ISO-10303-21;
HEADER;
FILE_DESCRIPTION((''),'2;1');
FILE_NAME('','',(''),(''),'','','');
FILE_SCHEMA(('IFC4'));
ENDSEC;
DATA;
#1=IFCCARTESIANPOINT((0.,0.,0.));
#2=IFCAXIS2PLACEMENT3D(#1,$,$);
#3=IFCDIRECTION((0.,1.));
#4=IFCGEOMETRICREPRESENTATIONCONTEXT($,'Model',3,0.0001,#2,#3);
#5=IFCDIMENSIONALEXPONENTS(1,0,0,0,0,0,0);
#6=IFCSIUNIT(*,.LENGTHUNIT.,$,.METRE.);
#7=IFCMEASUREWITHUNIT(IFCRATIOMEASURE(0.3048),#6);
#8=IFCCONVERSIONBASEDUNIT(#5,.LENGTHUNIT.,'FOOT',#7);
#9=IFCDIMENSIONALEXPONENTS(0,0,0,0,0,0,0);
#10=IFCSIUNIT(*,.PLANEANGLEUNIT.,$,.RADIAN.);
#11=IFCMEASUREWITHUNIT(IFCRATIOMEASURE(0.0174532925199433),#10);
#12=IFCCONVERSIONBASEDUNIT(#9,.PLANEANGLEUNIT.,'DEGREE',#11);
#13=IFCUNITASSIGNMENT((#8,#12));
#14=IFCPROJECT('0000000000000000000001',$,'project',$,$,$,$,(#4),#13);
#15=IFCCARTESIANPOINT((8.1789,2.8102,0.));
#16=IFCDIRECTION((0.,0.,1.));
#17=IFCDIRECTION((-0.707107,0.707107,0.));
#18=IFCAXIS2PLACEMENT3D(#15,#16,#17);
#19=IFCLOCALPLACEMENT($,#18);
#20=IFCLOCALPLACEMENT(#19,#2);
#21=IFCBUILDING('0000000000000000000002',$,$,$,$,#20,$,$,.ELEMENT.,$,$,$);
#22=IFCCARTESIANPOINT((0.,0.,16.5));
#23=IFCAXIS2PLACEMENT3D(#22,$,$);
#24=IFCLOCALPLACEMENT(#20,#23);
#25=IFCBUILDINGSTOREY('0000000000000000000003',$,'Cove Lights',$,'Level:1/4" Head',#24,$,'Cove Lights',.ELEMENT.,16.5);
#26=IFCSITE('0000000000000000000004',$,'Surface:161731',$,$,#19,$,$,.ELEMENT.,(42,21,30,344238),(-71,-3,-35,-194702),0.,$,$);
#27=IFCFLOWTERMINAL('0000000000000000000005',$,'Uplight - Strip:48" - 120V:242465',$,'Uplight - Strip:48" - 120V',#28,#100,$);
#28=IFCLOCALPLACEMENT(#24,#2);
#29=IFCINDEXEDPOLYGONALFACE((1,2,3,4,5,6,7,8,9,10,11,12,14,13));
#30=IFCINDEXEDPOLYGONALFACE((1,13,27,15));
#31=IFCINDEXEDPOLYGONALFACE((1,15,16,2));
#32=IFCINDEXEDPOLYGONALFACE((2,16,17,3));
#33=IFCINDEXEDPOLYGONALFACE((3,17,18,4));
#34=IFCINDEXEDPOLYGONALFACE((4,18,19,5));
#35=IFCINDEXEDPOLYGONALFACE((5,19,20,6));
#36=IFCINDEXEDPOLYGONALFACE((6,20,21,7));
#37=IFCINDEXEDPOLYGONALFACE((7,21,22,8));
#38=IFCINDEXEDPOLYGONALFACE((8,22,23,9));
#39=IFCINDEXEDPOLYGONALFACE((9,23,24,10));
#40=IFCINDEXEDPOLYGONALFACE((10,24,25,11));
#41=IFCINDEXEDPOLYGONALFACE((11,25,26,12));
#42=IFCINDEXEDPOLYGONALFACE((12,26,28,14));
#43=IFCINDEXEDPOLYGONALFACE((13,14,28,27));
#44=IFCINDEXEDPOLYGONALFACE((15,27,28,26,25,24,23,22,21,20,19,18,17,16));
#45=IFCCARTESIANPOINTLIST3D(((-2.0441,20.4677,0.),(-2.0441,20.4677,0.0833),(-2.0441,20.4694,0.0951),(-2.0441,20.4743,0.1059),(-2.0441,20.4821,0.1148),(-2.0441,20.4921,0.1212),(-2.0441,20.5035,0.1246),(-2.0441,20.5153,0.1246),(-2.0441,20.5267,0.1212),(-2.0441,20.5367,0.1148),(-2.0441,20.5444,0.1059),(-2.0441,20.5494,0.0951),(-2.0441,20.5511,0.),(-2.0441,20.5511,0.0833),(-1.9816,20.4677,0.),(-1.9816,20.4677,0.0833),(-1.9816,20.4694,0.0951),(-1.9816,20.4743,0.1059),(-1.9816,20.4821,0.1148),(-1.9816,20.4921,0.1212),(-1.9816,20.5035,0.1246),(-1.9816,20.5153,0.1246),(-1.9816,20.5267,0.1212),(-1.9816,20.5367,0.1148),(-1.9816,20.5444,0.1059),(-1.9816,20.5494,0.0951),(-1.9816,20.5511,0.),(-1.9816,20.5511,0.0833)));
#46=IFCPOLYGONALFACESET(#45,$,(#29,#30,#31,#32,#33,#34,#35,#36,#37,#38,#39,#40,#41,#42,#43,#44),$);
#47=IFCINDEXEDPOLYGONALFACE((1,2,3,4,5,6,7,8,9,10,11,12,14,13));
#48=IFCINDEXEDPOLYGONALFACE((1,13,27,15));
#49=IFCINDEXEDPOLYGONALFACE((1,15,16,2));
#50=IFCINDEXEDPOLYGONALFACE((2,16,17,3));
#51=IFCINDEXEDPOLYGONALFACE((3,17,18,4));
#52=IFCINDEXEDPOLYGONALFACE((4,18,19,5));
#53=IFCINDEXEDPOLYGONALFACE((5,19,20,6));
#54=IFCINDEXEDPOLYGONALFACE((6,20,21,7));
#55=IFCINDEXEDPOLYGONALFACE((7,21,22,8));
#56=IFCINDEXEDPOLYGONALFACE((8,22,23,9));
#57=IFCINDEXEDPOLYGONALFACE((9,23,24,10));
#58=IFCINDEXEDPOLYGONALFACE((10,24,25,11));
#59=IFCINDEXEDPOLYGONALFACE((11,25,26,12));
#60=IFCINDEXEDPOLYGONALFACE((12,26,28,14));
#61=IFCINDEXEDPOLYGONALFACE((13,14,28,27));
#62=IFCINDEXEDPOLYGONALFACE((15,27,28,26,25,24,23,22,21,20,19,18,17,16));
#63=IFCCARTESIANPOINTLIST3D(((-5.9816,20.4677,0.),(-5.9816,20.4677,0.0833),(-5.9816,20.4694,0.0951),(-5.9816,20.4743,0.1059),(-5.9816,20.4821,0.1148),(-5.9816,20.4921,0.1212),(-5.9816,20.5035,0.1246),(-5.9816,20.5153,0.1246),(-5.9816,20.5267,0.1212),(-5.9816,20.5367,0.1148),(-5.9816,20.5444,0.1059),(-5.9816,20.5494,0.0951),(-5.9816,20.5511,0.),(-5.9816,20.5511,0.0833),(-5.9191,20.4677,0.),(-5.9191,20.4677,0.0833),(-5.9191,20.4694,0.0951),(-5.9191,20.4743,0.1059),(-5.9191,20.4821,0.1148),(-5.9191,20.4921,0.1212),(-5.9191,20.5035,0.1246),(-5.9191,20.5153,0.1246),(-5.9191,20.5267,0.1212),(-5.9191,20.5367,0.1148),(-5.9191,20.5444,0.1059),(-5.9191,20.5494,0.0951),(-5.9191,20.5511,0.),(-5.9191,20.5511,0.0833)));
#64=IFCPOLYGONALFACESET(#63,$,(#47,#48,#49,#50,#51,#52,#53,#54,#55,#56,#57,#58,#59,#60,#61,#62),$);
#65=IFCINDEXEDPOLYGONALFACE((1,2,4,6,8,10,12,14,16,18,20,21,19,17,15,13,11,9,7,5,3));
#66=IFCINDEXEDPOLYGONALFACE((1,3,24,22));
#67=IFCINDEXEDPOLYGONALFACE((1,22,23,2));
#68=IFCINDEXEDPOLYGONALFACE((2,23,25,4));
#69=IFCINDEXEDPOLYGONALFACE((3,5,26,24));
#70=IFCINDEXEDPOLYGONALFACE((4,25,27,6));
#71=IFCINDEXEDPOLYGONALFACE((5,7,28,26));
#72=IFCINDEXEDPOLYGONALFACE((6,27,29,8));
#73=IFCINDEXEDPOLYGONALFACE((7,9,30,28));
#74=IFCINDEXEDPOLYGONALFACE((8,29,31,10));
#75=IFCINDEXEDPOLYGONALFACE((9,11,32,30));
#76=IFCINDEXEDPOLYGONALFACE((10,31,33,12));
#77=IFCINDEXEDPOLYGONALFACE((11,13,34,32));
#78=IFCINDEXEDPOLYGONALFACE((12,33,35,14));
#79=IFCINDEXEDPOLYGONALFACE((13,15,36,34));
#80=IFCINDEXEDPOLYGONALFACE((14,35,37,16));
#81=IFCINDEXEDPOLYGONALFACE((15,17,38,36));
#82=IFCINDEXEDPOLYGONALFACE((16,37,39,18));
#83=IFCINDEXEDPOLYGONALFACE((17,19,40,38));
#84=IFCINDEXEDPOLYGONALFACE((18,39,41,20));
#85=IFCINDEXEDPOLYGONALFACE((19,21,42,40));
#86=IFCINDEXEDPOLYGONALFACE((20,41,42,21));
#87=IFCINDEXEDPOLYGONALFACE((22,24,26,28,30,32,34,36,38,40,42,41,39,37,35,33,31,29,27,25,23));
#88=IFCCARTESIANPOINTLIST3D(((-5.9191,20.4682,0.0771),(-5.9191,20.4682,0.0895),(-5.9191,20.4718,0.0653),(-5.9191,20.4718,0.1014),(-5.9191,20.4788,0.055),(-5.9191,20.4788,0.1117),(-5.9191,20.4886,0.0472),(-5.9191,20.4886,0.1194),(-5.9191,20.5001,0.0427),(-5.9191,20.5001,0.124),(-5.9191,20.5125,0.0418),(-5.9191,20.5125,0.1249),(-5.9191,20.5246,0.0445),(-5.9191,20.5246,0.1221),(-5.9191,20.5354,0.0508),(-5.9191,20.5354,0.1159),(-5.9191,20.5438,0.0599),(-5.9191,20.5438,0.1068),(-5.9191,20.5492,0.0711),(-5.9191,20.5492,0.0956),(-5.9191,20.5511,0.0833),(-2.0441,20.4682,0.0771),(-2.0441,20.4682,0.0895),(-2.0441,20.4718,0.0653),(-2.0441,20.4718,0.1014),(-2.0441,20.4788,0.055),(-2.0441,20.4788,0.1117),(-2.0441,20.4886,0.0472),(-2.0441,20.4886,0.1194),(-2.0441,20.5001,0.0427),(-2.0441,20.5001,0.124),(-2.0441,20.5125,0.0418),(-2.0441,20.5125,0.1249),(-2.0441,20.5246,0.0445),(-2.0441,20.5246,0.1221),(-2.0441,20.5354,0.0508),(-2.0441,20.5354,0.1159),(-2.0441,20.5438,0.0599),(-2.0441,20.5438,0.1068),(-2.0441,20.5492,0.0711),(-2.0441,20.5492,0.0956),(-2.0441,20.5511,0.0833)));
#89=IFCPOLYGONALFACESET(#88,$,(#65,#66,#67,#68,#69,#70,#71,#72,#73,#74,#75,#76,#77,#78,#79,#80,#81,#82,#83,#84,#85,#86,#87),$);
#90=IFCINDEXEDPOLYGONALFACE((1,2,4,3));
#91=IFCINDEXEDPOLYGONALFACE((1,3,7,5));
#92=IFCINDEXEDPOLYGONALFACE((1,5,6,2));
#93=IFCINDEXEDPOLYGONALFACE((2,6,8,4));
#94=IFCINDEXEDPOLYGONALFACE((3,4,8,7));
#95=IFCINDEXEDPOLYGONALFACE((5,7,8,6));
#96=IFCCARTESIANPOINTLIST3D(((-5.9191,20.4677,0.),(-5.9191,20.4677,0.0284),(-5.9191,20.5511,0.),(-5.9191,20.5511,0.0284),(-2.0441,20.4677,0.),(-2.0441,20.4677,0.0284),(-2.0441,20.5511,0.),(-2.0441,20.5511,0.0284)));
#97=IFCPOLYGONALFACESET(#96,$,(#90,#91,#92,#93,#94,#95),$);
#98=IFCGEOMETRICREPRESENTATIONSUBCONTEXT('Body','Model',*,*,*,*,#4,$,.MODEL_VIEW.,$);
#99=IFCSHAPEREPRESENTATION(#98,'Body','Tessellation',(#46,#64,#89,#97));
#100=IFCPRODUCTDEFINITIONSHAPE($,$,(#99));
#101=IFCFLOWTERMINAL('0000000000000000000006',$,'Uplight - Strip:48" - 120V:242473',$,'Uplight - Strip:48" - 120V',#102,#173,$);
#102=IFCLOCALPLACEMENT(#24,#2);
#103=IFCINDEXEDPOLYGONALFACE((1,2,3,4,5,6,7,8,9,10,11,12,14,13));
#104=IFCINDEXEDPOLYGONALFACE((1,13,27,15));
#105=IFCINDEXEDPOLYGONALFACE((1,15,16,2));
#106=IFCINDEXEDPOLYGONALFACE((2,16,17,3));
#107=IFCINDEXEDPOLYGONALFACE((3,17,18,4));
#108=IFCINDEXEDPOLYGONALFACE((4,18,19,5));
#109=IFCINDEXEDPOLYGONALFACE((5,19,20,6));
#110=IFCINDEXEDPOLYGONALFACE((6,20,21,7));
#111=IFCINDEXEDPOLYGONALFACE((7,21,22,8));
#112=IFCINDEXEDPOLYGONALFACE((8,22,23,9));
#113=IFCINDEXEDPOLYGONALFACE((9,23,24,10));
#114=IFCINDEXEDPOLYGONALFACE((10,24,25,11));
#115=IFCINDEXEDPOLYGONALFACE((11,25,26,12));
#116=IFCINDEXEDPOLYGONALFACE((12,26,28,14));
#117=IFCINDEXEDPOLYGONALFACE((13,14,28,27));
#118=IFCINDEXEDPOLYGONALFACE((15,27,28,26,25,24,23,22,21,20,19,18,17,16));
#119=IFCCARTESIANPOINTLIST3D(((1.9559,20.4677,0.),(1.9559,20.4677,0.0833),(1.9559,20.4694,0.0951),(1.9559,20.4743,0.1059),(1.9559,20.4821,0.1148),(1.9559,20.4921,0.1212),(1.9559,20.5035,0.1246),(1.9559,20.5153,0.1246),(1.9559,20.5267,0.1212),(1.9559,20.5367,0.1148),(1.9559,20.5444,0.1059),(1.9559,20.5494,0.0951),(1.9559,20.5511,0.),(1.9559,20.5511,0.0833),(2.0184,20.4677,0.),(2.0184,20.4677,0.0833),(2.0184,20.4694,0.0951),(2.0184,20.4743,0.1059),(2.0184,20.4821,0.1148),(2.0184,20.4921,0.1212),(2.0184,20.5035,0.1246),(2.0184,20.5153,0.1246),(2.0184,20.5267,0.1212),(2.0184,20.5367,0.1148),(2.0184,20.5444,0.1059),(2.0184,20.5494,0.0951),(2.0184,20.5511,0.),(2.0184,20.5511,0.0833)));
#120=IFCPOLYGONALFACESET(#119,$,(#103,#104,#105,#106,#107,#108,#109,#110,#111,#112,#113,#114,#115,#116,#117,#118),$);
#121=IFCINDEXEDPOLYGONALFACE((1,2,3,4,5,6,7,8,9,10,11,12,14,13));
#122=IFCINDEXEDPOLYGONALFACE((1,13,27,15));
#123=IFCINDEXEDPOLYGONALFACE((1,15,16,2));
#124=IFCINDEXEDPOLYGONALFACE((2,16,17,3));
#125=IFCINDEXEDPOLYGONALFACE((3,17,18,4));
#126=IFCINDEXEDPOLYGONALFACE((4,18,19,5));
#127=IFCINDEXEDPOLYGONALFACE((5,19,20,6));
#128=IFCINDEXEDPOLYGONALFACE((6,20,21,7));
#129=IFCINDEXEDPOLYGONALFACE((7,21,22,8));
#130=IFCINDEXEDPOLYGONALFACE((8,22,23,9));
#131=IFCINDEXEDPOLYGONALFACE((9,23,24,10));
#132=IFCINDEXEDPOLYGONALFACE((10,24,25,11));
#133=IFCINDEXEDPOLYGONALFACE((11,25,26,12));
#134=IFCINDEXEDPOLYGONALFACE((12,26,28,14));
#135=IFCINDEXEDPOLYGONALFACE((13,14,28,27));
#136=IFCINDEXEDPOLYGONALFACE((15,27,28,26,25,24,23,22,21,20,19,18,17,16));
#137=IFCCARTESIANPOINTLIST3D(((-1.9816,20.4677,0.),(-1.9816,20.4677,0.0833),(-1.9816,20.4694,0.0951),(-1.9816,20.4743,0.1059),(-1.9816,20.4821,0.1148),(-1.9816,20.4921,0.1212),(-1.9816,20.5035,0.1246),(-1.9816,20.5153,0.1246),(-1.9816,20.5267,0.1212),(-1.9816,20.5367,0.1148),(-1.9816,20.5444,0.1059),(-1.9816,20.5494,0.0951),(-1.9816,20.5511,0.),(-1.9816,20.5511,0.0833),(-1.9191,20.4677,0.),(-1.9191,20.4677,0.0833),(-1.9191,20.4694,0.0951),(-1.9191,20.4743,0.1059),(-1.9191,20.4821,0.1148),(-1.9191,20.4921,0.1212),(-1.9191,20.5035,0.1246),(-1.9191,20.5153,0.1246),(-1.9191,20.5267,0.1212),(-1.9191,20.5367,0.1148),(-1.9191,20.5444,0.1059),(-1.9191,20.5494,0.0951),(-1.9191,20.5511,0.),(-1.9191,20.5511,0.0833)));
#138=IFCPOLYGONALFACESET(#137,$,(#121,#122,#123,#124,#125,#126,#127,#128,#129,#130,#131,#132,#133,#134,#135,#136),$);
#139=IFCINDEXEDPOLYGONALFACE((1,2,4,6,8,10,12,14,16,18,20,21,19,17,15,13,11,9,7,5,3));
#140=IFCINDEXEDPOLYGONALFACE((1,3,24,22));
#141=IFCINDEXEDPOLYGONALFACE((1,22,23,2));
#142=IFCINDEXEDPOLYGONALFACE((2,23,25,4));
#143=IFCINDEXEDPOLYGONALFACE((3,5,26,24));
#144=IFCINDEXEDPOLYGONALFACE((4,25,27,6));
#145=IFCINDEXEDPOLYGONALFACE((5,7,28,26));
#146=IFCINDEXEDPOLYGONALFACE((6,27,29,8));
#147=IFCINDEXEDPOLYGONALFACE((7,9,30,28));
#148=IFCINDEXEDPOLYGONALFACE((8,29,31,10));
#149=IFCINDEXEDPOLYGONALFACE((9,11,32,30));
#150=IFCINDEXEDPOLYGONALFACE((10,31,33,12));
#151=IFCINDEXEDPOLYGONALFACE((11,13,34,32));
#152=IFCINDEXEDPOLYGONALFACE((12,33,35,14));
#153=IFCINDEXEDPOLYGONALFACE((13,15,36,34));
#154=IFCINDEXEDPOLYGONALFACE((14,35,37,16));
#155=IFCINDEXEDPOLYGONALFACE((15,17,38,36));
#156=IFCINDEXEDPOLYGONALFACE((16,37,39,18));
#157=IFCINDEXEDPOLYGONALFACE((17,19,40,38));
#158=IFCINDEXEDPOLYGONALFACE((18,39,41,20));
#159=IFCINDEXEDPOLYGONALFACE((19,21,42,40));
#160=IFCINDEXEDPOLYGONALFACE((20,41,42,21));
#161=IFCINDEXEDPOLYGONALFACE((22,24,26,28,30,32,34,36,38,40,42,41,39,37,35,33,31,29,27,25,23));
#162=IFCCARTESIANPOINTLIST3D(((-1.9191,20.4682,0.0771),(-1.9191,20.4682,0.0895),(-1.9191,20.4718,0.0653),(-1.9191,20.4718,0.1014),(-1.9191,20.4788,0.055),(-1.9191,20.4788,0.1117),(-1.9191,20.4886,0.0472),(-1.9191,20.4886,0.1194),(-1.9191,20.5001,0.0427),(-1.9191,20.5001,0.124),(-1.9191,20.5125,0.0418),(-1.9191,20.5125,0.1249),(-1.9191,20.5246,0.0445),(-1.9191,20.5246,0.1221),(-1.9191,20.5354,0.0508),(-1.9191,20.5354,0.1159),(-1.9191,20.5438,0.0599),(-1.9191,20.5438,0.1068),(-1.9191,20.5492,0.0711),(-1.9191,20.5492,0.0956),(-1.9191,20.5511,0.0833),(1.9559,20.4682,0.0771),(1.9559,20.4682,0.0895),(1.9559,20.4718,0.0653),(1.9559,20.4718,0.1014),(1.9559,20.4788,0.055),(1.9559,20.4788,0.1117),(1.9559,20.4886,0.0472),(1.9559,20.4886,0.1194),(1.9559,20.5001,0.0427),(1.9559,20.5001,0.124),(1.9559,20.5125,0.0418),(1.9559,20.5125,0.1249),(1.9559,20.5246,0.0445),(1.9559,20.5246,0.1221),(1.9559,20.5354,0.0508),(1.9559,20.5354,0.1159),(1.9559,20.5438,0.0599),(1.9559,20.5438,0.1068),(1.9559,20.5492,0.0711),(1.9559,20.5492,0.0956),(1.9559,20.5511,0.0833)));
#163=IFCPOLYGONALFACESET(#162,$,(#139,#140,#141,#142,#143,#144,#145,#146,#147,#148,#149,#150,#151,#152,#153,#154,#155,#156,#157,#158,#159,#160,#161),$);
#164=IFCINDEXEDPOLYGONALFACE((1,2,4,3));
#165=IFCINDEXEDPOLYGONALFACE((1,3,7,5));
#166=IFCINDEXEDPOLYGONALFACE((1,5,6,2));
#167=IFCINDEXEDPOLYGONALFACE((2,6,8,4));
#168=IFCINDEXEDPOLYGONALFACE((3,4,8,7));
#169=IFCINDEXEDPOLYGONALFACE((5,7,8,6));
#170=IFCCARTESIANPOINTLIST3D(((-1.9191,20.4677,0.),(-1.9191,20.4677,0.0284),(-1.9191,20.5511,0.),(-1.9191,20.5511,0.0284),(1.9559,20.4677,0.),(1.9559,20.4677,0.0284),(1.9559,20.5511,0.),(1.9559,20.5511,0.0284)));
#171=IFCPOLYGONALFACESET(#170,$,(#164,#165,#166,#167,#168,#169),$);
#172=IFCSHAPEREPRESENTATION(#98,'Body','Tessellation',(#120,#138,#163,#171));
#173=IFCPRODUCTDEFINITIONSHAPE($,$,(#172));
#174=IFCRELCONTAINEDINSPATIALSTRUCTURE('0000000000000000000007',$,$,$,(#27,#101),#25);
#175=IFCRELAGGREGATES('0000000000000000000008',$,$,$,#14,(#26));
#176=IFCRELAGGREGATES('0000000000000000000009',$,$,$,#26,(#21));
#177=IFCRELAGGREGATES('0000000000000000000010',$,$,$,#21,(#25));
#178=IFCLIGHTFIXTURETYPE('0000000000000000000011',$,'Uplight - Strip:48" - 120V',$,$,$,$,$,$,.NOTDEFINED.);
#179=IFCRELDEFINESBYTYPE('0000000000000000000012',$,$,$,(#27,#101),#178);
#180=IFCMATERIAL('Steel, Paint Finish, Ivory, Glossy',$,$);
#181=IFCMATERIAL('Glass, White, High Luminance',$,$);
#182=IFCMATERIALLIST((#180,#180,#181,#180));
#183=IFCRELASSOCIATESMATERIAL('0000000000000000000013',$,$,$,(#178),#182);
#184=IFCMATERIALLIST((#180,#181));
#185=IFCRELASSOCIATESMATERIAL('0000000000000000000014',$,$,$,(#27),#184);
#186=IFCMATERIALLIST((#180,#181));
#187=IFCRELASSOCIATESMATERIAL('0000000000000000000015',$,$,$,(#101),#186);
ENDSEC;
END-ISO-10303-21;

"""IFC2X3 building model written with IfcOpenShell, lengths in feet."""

from ifc_helpers import new_model, entity, si_unit, converted_unit, direction, frame, frame_2d, origin, origin_2d_with_axis, place, context, subcontext, project, spatial, polyline, circle_curve, parameter, trimmed, segment, composite_curve, rectangle, circle, outline, extrude, source, transform, mapped, material, material_list, type_object, type_shapes, element, save


model = new_model("IFC2X3")

# Units and contexts
model_context = context("Model", 3, precision=0.0001, world=origin(), true_north=direction((0.0, 1.0)))
body_context = subcontext(model_context, "Body", "Model", "MODEL_VIEW")
ifc_project = project(units=[converted_unit("LENGTHUNIT", "FOOT", entity("IfcRatioMeasure", 0.3048), si_unit("LENGTHUNIT", "METRE"), dimensions=[1, 0, 0, 0, 0, 0, 0]), converted_unit("PLANEANGLEUNIT", "DEGREE", entity("IfcRatioMeasure", 0.0174532925199433), si_unit("PLANEANGLEUNIT", "RADIAN"), dimensions=[0, 0, 0, 0, 0, 0, 0])], contexts=[model_context])

# Site, building, storey
site_placement = place(None, frame((8.1789, 2.8102, 0.0), z_axis=(0.0, 0.0, 1.0), x_axis=(-0.707107, 0.707107, 0.0)))
site = spatial("IfcSite", under=ifc_project, at=site_placement, Name="Surface:161731", CompositionType="ELEMENT", RefLatitude=(42, 21, 30, 344238), RefLongitude=(-71, -3, -35, -194702), RefElevation=0.0)
building_placement = place(site_placement, origin())
building = spatial("IfcBuilding", under=site, at=building_placement, CompositionType="ELEMENT")
storey_placement = place(building_placement, frame((0.0, 0.0, 16.5)))
storey = spatial("IfcBuildingStorey", under=building, at=storey_placement, Name="Cove Lights", ObjectType="Level:1/4\" Head", LongName="Cove Lights", CompositionType="ELEMENT", Elevation=16.5)

# Flow terminals
ifc_material_1 = material(Name="Steel, Paint Finish, Ivory, Glossy")
ifc_material_2 = material(Name="Glass, White, High Luminance")
ifc_material_list_1 = material_list([ifc_material_1, ifc_material_1, ifc_material_2, ifc_material_1])
light_fixture_type_1 = type_object("IfcLightFixtureType", Name="Uplight - Strip:48\" - 120V", PredefinedType="NOTDEFINED", material=ifc_material_list_1)
shared_shape_1 = source(origin(), body_context, "Body", "SweptSolid", [
    extrude(outline(composite_curve([segment(polyline([(-0.0417, -0.0417), (0.0417, -0.0417)]), True, "CONTINUOUS"), segment(trimmed(circle_curve(frame_2d((0.0417, 0.0), x_axis=(0.0, -1.0)), 0.0417), [parameter(0.0)], [parameter(180.0)], True, "PARAMETER"), True, "CONTINUOUS"), segment(polyline([(0.0417, 0.0417), (-0.0417, 0.0417)]), True, "CONTINUOUS"), segment(polyline([(-0.0417, 0.0417), (-0.0417, -0.0417)]), True, "CONTINUOUS")], self_intersect=False)), frame((1.9375, 0.0, 0.0417), z_axis=(1.0, 0.0, 0.0), x_axis=(0.0, 0.0, 1.0)), (0.0, 0.0, 1.0), 0.0625),
    extrude(outline(composite_curve([segment(polyline([(-0.0417, -0.0417), (0.0417, -0.0417)]), True, "CONTINUOUS"), segment(polyline([(0.0417, -0.0417), (0.0417, 0.0417)]), True, "CONTINUOUS"), segment(trimmed(circle_curve(frame_2d((0.0, 0.0417), x_axis=(0.0, 1.0)), 0.0417), [parameter(270.0)], [parameter(90.0)], True, "PARAMETER"), True, "CONTINUOUS"), segment(polyline([(-0.0417, 0.0417), (-0.0417, -0.0417)]), True, "CONTINUOUS")], self_intersect=False)), frame((-2.0, 0.0, 0.0417), z_axis=(1.0, 0.0, 0.0), x_axis=(0.0, 1.0, 0.0)), (0.0, 0.0, 1.0), 0.0625),
    extrude(circle(Radius=0.0417, at=frame_2d((0.0, 0.0), x_axis=(1.0, 0.0))), frame((-1.9375, 0.0, 0.0833), z_axis=(1.0, 0.0, 0.0), x_axis=(0.0, 1.0, 0.0)), (0.0, 0.0, 1.0), 3.875),
    extrude(rectangle(XDim=3.875, YDim=0.0833, at=origin_2d_with_axis()), frame((0.0, 0.0, 0.0), z_axis=(0.0, 0.0, 1.0), x_axis=(-1.0, 0.0, 0.0)), (0.0, 0.0, 1.0), 0.0284),
])
type_shapes(light_fixture_type_1, [shared_shape_1])
ifc_material_list_2 = material_list([ifc_material_1, ifc_material_2])
flow_terminal_1_placement = place(storey_placement, frame((-3.9816, 20.5094, 0.0)))
element("IfcFlowTerminal", 1, at=flow_terminal_1_placement, inside=storey, type_object=light_fixture_type_1, material=ifc_material_list_2, Name="Uplight - Strip:48\" - 120V:242465", ObjectType="Uplight - Strip:48\" - 120V", context=body_context, shape_type="MappedRepresentation", body=[
    mapped(shared_shape_1, transform((0.0, 0.0, 0.0), scale=1.0)),
])
ifc_material_list_3 = material_list([ifc_material_1, ifc_material_2])
flow_terminal_2_placement = place(storey_placement, frame((0.0184, 20.5094, 0.0)))
element("IfcFlowTerminal", 2, at=flow_terminal_2_placement, inside=storey, type_object=light_fixture_type_1, material=ifc_material_list_3, Name="Uplight - Strip:48\" - 120V:242473", ObjectType="Uplight - Strip:48\" - 120V", context=body_context, shape_type="MappedRepresentation", body=[
    mapped(shared_shape_1, transform((0.0, 0.0, 0.0), scale=1.0)),
])

save(model, "model.ifc")
